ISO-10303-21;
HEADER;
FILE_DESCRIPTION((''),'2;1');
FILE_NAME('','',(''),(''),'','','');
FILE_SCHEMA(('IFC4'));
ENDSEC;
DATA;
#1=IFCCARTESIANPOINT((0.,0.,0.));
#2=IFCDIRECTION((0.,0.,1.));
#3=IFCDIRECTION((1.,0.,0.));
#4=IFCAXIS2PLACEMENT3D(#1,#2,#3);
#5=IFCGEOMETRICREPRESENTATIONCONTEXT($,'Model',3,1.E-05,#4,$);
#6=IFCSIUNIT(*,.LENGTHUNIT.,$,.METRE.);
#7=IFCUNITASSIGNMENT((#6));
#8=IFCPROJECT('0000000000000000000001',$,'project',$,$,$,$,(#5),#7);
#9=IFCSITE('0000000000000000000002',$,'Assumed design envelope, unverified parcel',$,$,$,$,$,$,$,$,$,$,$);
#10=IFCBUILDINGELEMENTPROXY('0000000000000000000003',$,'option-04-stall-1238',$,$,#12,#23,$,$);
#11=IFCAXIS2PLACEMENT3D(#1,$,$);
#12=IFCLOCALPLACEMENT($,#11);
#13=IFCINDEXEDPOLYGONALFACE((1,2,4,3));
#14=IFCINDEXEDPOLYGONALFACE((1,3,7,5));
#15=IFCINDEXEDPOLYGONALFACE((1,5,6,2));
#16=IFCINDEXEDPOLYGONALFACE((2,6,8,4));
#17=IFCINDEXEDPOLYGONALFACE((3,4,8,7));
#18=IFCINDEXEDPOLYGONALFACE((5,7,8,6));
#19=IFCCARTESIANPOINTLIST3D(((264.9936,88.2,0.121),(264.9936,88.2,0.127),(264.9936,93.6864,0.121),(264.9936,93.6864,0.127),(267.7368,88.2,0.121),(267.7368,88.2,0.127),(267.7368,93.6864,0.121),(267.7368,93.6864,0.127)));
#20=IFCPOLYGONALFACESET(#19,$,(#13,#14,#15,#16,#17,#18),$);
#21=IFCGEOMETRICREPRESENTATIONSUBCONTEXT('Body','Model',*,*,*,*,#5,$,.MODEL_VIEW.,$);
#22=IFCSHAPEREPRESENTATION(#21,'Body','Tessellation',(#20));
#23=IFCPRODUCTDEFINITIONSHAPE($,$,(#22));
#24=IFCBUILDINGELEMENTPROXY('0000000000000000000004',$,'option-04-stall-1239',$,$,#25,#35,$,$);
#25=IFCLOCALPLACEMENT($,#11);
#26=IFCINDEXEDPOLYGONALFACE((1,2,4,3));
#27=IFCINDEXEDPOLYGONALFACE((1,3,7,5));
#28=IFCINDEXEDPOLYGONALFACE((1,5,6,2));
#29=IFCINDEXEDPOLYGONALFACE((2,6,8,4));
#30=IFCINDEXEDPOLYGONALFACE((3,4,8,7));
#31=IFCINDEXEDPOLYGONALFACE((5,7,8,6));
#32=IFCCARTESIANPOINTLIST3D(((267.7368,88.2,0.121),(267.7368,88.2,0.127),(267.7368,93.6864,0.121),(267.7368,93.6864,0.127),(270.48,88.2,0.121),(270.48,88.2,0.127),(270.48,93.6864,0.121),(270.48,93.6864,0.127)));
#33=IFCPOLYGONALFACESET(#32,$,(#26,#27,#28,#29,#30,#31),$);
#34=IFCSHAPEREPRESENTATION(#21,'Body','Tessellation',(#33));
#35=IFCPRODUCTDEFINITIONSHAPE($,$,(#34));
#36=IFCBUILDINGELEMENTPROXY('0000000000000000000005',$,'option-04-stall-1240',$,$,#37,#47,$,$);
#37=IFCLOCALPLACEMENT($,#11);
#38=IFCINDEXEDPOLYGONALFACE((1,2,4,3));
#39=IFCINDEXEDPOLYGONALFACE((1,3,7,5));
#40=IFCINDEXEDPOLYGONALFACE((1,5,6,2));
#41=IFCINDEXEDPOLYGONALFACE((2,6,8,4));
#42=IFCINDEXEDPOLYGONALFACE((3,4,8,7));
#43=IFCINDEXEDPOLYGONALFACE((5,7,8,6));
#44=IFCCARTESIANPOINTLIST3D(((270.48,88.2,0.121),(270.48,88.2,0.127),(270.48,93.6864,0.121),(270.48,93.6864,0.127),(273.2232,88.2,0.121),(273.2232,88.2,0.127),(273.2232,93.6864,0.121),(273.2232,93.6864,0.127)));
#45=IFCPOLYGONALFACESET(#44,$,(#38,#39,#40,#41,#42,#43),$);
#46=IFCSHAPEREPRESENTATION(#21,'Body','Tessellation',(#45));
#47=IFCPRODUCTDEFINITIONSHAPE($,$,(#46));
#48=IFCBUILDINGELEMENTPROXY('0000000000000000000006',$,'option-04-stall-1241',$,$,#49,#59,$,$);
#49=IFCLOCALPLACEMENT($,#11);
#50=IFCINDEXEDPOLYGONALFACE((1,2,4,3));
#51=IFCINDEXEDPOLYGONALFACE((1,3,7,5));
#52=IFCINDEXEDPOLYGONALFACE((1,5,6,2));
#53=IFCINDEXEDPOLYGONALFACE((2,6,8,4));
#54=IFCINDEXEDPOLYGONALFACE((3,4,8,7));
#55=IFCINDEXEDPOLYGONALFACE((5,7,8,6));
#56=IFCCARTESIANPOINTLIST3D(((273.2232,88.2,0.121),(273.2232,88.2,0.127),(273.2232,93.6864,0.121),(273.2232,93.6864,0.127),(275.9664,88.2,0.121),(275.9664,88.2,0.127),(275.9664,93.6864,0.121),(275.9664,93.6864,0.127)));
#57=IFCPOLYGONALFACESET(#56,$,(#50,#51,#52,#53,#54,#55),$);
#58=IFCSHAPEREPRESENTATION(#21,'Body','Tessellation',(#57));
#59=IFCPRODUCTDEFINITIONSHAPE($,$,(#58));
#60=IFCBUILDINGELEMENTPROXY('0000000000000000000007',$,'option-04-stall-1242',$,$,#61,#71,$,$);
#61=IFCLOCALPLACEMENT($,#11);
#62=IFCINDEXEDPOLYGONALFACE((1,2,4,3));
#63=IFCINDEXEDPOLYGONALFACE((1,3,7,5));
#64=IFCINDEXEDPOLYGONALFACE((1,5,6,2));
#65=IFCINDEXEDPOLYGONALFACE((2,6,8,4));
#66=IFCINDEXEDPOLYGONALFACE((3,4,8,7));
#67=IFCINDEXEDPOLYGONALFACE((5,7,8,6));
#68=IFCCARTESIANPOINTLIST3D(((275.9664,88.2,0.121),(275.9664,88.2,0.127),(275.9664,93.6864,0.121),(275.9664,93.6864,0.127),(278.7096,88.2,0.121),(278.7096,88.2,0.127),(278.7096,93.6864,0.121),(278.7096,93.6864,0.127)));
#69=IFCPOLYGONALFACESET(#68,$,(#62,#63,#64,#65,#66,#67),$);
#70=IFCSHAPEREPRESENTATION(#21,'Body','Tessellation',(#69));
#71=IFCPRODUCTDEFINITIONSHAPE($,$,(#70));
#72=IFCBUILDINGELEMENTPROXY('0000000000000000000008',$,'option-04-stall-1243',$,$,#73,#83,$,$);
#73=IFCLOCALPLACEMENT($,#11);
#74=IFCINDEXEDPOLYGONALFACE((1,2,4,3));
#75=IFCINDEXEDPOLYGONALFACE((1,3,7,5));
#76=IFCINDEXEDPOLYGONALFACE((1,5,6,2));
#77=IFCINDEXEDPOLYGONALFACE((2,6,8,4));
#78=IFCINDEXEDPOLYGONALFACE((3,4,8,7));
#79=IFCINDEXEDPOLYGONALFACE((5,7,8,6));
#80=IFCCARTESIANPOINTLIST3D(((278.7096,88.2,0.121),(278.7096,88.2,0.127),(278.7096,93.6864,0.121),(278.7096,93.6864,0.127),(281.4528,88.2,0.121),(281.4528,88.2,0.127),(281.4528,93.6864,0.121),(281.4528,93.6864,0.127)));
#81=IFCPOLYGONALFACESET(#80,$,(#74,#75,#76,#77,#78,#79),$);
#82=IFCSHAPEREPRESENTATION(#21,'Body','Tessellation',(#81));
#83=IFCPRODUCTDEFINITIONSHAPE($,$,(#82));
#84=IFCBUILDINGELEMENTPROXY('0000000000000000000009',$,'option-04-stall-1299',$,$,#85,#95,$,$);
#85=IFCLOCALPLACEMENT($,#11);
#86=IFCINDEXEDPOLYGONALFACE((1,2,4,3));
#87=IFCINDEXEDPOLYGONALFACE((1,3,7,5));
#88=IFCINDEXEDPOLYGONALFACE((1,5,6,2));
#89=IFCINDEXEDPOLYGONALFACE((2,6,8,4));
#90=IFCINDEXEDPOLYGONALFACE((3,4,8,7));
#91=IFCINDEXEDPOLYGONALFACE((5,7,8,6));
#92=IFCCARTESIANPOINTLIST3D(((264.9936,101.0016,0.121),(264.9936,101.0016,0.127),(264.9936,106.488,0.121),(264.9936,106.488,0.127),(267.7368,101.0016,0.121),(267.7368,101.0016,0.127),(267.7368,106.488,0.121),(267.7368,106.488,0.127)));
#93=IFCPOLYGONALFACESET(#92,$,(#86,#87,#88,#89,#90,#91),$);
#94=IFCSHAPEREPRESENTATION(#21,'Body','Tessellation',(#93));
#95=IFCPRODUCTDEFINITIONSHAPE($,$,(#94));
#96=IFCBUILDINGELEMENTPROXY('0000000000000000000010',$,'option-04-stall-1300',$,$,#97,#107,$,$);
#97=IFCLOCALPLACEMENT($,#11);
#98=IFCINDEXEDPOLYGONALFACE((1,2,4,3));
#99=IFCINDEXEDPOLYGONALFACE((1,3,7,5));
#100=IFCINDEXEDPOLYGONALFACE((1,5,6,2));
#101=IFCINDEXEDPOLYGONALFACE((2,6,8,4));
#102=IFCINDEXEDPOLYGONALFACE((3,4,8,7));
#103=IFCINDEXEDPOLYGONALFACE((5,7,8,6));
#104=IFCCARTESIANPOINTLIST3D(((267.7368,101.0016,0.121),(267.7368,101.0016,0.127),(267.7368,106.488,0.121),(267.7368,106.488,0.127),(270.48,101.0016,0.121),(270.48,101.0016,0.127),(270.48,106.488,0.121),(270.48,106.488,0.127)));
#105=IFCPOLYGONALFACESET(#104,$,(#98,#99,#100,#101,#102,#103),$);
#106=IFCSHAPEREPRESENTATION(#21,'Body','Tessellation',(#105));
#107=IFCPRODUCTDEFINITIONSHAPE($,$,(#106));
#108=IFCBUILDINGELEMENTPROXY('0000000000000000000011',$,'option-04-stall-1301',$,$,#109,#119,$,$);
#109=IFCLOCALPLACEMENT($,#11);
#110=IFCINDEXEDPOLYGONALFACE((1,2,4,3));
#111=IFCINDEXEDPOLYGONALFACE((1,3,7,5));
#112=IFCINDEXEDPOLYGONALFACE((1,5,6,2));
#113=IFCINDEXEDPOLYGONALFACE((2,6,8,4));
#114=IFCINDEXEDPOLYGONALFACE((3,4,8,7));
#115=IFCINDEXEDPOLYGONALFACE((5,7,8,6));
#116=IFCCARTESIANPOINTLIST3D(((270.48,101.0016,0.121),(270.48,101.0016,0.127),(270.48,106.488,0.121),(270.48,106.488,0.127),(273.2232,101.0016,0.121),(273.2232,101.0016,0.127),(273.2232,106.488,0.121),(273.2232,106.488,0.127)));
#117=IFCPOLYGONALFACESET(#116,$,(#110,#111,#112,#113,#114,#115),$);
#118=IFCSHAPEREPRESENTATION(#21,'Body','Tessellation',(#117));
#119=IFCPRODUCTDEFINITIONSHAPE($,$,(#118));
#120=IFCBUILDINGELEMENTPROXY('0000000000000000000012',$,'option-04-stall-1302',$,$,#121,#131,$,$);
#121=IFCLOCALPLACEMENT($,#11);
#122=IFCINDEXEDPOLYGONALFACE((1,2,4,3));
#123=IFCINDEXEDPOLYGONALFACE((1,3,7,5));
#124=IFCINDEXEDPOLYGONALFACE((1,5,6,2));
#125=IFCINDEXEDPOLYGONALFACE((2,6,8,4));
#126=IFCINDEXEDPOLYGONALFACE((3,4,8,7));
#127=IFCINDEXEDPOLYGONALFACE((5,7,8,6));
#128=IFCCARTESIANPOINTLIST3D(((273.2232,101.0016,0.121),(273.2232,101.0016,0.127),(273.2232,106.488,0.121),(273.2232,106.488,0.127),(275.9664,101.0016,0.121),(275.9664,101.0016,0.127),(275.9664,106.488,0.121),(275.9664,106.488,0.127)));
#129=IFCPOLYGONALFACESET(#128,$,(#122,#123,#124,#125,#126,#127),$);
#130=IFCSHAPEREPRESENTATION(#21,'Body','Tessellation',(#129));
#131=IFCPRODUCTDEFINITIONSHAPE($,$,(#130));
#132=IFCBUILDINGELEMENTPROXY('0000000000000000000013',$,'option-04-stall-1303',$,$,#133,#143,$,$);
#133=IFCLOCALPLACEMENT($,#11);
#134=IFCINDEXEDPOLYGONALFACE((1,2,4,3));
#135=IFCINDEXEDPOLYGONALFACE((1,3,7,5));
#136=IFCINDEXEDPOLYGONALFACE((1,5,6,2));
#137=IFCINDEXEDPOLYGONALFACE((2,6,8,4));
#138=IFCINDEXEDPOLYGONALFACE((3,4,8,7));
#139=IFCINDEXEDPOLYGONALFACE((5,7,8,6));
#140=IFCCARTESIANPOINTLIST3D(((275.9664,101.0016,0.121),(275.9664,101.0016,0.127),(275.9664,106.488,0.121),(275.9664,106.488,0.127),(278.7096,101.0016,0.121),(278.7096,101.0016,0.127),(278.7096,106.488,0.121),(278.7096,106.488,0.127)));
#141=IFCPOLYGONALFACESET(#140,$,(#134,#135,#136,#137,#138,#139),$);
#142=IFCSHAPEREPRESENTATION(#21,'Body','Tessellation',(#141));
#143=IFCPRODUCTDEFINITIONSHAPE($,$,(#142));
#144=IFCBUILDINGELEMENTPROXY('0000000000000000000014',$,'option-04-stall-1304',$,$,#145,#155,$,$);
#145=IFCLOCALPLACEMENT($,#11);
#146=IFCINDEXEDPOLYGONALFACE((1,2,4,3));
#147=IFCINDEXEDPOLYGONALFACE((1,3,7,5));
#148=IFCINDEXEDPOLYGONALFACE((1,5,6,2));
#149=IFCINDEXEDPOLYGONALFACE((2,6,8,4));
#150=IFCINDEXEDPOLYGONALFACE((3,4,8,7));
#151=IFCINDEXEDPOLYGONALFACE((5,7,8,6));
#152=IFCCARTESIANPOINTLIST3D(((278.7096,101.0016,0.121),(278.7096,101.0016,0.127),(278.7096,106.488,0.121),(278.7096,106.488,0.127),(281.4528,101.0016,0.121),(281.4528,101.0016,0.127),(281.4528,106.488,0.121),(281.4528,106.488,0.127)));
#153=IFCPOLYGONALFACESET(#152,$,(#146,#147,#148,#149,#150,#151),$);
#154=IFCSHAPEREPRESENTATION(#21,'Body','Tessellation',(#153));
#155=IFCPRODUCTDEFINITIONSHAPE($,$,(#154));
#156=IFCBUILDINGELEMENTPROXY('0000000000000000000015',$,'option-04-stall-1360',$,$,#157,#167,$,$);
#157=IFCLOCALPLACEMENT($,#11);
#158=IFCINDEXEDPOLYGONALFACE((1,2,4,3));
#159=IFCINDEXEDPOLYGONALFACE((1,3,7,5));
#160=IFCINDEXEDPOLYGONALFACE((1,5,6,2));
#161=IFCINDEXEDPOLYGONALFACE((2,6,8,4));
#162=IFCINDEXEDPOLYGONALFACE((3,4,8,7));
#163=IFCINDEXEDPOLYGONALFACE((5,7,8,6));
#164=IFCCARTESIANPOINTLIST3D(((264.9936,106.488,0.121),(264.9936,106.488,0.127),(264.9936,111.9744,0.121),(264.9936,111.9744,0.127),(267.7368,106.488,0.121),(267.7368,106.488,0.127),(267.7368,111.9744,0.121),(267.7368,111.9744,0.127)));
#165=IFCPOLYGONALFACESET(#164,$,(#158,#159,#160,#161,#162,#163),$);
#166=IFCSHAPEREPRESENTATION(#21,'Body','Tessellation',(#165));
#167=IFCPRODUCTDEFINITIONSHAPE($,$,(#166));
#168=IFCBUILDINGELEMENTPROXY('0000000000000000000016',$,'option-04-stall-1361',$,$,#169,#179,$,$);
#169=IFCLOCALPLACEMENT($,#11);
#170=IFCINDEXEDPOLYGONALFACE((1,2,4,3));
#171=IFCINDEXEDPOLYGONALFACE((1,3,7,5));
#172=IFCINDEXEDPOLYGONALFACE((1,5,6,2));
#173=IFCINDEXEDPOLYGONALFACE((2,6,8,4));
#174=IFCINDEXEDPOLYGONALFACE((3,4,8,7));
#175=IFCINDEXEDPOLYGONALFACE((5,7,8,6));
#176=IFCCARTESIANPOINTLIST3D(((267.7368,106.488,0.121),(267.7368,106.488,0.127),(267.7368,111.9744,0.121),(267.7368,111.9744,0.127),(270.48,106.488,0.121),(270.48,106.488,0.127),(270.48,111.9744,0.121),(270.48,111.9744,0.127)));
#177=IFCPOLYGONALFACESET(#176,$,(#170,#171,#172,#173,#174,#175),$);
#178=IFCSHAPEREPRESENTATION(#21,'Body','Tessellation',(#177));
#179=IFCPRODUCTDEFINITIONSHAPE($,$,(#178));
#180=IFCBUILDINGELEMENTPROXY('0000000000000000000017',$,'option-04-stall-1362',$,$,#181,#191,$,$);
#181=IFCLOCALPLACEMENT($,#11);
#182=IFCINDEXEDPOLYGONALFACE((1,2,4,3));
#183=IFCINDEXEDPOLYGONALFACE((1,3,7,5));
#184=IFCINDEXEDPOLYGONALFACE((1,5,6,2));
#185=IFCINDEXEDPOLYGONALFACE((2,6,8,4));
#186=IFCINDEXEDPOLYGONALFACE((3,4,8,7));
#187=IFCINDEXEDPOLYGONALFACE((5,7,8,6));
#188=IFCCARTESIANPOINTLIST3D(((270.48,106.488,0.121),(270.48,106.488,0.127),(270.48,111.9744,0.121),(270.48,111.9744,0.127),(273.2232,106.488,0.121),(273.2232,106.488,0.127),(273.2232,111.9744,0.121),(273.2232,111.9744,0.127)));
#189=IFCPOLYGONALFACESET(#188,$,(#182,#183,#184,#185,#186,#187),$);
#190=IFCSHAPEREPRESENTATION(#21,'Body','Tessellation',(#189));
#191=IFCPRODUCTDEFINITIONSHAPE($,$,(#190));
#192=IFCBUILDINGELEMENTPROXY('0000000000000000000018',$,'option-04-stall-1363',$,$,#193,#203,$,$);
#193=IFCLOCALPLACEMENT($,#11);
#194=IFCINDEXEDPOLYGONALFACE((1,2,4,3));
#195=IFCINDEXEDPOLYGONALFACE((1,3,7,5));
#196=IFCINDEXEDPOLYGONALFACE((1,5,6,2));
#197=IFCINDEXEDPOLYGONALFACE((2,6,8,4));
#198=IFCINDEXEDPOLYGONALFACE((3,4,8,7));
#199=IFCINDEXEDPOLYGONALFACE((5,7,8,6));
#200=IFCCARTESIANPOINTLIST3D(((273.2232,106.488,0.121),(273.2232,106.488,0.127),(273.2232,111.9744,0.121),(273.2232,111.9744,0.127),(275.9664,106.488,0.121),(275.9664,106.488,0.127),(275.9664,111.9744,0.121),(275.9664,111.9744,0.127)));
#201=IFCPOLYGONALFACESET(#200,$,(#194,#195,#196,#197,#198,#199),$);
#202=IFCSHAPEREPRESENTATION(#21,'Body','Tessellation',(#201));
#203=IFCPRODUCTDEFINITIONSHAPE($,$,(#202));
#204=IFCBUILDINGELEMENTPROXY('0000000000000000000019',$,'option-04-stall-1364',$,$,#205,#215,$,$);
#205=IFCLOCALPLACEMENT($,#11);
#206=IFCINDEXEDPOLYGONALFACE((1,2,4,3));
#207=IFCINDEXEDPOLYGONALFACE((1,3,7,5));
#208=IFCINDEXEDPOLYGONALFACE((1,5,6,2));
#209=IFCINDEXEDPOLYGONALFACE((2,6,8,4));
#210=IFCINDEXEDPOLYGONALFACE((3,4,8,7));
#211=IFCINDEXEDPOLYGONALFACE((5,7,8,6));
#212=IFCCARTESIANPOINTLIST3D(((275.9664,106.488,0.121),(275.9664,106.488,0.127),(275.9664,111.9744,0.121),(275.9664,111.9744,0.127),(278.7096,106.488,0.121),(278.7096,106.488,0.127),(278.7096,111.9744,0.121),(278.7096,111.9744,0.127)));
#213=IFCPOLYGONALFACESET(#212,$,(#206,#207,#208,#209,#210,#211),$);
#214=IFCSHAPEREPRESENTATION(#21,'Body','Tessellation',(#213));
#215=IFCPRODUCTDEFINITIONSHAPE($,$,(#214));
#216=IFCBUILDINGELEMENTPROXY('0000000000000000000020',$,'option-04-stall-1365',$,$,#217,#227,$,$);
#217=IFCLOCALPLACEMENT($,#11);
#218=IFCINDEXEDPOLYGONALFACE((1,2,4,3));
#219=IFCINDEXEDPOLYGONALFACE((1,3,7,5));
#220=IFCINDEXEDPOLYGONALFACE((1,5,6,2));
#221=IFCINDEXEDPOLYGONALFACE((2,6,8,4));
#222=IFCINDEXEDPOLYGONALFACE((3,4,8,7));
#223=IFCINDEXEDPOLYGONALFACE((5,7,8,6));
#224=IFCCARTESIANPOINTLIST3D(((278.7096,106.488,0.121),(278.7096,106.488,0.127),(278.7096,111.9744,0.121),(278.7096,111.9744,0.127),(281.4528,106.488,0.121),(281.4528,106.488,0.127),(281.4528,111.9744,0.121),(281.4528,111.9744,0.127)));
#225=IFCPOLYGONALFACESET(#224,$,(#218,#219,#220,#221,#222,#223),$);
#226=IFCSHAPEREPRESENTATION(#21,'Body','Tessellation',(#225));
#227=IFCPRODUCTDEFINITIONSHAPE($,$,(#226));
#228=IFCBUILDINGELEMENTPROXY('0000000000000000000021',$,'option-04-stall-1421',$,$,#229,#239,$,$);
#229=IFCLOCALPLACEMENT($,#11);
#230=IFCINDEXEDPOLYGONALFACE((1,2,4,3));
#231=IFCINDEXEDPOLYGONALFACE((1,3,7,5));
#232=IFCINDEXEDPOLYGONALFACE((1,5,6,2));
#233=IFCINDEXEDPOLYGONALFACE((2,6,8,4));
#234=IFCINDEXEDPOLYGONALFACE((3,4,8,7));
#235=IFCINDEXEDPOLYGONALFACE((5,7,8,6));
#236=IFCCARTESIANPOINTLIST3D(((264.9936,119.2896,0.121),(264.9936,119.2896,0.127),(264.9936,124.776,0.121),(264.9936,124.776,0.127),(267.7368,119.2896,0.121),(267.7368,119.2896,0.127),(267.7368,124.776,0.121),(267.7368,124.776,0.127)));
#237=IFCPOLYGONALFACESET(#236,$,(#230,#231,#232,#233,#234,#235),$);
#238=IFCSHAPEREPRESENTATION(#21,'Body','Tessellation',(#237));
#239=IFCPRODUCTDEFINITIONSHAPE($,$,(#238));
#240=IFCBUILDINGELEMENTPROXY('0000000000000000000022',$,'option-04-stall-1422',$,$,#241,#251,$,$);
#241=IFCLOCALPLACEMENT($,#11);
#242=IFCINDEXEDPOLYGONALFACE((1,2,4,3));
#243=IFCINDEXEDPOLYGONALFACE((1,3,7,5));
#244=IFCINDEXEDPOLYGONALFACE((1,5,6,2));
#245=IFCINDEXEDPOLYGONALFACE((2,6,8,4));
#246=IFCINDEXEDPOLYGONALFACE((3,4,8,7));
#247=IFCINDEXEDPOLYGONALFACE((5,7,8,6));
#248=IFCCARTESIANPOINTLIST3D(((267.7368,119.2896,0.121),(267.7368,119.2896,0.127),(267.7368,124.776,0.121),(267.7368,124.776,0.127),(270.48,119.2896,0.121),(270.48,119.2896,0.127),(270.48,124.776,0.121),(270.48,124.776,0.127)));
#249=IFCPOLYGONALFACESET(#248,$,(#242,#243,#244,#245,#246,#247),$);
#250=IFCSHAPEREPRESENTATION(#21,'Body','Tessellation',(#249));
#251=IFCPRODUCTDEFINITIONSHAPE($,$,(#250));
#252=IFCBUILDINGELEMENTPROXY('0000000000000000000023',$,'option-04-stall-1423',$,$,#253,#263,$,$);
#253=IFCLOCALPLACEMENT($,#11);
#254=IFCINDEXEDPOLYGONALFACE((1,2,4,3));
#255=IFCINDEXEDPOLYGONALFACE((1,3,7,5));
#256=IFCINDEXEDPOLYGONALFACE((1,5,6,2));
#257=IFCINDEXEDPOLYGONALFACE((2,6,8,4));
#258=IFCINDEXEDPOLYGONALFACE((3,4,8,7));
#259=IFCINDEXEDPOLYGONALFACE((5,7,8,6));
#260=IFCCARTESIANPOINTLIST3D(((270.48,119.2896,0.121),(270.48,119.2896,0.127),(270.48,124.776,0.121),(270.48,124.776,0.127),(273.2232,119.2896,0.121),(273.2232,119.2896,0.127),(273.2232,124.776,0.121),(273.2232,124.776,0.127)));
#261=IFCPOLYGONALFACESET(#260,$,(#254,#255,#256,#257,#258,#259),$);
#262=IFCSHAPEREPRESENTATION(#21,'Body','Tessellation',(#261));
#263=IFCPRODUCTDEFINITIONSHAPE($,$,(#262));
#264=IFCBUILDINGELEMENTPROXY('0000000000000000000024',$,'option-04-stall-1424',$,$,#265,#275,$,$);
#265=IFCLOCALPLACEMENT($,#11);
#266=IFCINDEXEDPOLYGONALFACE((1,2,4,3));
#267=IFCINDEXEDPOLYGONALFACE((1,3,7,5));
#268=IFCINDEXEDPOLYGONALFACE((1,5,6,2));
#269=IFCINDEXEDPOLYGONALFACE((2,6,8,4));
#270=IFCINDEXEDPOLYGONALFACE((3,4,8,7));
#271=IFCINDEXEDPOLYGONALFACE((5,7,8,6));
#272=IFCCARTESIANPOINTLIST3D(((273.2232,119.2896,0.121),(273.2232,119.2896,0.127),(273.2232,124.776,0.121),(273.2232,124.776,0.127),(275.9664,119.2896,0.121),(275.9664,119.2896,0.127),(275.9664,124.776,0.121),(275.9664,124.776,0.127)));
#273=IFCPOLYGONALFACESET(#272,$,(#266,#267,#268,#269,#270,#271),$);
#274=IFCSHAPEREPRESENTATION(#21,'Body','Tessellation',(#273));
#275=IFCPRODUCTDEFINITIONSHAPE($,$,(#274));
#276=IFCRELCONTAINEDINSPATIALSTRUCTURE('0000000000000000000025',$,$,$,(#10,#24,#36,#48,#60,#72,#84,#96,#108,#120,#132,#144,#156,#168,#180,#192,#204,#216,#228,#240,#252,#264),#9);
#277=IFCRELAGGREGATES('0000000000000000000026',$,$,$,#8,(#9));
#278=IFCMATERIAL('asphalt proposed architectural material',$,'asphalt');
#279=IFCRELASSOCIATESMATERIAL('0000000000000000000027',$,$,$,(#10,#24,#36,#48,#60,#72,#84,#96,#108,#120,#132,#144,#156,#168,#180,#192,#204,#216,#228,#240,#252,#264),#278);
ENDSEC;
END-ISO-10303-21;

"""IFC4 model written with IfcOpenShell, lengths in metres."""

from ifc_helpers import new_model, si_unit, frame, origin_with_axes, place, context, subcontext, project, spatial, rectangle, extrude, material, element, save


model = new_model("IFC4")

# Units and contexts
model_context = context("Model", 3, precision=1e-05, world=origin_with_axes())
body_context = subcontext(model_context, "Body", "Model", "MODEL_VIEW")
ifc_project = project(units=[si_unit("LENGTHUNIT", "METRE")], contexts=[model_context])

# Site
site = spatial("IfcSite", under=ifc_project, Name="Assumed design envelope, unverified parcel")

# Building element proxies
ifc_material = material(Name="asphalt proposed architectural material", Category="asphalt")
for number, where, z_axis, x_axis, name in (
    (1, (266.3652, 90.9432, 0.121), (0.0, 0.0, 1.0), (1.0, 0.0, 0.0), "option-04-stall-1238"),
    (2, (269.1084, 90.9432, 0.121), (0.0, 0.0, 1.0), (1.0, 0.0, 0.0), "option-04-stall-1239"),
    (3, (271.8516, 90.9432, 0.121), (0.0, 0.0, 1.0), (1.0, 0.0, 0.0), "option-04-stall-1240"),
    (4, (274.5948, 90.9432, 0.121), (0.0, 0.0, 1.0), (1.0, 0.0, 0.0), "option-04-stall-1241"),
    (5, (277.338, 90.9432, 0.121), (0.0, 0.0, 1.0), (1.0, 0.0, 0.0), "option-04-stall-1242"),
    (6, (280.0812, 90.9432, 0.121), (0.0, 0.0, 1.0), (1.0, 0.0, 0.0), "option-04-stall-1243"),
    (7, (266.3652, 103.7448, 0.121), (0.0, 0.0, 1.0), (1.0, 0.0, 0.0), "option-04-stall-1299"),
    (8, (269.1084, 103.7448, 0.121), (0.0, 0.0, 1.0), (1.0, 0.0, 0.0), "option-04-stall-1300"),
    (9, (271.8516, 103.7448, 0.121), (0.0, 0.0, 1.0), (1.0, 0.0, 0.0), "option-04-stall-1301"),
    (10, (274.5948, 103.7448, 0.121), (0.0, 0.0, 1.0), (1.0, 0.0, 0.0), "option-04-stall-1302"),
    (11, (277.338, 103.7448, 0.121), (0.0, 0.0, 1.0), (1.0, 0.0, 0.0), "option-04-stall-1303"),
    (12, (280.0812, 103.7448, 0.121), (0.0, 0.0, 1.0), (1.0, 0.0, 0.0), "option-04-stall-1304"),
    (13, (266.3652, 109.2312, 0.121), (0.0, 0.0, 1.0), (1.0, 0.0, 0.0), "option-04-stall-1360"),
    (14, (269.1084, 109.2312, 0.121), (0.0, 0.0, 1.0), (1.0, 0.0, 0.0), "option-04-stall-1361"),
    (15, (271.8516, 109.2312, 0.121), (0.0, 0.0, 1.0), (1.0, 0.0, 0.0), "option-04-stall-1362"),
    (16, (274.5948, 109.2312, 0.121), (0.0, 0.0, 1.0), (1.0, 0.0, 0.0), "option-04-stall-1363"),
    (17, (277.338, 109.2312, 0.121), (0.0, 0.0, 1.0), (1.0, 0.0, 0.0), "option-04-stall-1364"),
    (18, (280.0812, 109.2312, 0.121), (0.0, 0.0, 1.0), (1.0, 0.0, 0.0), "option-04-stall-1365"),
    (19, (266.3652, 122.0328, 0.121), (0.0, 0.0, 1.0), (1.0, 0.0, 0.0), "option-04-stall-1421"),
    (20, (269.1084, 122.0328, 0.121), (0.0, 0.0, 1.0), (1.0, 0.0, 0.0), "option-04-stall-1422"),
    (21, (271.8516, 122.0328, 0.121), (0.0, 0.0, 1.0), (1.0, 0.0, 0.0), "option-04-stall-1423"),
    (22, (274.5948, 122.0328, 0.121), (0.0, 0.0, 1.0), (1.0, 0.0, 0.0), "option-04-stall-1424"),
):
    element("IfcBuildingElementProxy", number, at=place(None, frame(where, z_axis=z_axis, x_axis=x_axis)), inside=site, material=ifc_material, Name=name, context=body_context, shape_type="SweptSolid", body=[
        extrude(rectangle(XDim=2.7432, YDim=5.4864), origin_with_axes(), (0.0, 0.0, 1.0), 0.006),
    ])

save(model, "model.ifc")
